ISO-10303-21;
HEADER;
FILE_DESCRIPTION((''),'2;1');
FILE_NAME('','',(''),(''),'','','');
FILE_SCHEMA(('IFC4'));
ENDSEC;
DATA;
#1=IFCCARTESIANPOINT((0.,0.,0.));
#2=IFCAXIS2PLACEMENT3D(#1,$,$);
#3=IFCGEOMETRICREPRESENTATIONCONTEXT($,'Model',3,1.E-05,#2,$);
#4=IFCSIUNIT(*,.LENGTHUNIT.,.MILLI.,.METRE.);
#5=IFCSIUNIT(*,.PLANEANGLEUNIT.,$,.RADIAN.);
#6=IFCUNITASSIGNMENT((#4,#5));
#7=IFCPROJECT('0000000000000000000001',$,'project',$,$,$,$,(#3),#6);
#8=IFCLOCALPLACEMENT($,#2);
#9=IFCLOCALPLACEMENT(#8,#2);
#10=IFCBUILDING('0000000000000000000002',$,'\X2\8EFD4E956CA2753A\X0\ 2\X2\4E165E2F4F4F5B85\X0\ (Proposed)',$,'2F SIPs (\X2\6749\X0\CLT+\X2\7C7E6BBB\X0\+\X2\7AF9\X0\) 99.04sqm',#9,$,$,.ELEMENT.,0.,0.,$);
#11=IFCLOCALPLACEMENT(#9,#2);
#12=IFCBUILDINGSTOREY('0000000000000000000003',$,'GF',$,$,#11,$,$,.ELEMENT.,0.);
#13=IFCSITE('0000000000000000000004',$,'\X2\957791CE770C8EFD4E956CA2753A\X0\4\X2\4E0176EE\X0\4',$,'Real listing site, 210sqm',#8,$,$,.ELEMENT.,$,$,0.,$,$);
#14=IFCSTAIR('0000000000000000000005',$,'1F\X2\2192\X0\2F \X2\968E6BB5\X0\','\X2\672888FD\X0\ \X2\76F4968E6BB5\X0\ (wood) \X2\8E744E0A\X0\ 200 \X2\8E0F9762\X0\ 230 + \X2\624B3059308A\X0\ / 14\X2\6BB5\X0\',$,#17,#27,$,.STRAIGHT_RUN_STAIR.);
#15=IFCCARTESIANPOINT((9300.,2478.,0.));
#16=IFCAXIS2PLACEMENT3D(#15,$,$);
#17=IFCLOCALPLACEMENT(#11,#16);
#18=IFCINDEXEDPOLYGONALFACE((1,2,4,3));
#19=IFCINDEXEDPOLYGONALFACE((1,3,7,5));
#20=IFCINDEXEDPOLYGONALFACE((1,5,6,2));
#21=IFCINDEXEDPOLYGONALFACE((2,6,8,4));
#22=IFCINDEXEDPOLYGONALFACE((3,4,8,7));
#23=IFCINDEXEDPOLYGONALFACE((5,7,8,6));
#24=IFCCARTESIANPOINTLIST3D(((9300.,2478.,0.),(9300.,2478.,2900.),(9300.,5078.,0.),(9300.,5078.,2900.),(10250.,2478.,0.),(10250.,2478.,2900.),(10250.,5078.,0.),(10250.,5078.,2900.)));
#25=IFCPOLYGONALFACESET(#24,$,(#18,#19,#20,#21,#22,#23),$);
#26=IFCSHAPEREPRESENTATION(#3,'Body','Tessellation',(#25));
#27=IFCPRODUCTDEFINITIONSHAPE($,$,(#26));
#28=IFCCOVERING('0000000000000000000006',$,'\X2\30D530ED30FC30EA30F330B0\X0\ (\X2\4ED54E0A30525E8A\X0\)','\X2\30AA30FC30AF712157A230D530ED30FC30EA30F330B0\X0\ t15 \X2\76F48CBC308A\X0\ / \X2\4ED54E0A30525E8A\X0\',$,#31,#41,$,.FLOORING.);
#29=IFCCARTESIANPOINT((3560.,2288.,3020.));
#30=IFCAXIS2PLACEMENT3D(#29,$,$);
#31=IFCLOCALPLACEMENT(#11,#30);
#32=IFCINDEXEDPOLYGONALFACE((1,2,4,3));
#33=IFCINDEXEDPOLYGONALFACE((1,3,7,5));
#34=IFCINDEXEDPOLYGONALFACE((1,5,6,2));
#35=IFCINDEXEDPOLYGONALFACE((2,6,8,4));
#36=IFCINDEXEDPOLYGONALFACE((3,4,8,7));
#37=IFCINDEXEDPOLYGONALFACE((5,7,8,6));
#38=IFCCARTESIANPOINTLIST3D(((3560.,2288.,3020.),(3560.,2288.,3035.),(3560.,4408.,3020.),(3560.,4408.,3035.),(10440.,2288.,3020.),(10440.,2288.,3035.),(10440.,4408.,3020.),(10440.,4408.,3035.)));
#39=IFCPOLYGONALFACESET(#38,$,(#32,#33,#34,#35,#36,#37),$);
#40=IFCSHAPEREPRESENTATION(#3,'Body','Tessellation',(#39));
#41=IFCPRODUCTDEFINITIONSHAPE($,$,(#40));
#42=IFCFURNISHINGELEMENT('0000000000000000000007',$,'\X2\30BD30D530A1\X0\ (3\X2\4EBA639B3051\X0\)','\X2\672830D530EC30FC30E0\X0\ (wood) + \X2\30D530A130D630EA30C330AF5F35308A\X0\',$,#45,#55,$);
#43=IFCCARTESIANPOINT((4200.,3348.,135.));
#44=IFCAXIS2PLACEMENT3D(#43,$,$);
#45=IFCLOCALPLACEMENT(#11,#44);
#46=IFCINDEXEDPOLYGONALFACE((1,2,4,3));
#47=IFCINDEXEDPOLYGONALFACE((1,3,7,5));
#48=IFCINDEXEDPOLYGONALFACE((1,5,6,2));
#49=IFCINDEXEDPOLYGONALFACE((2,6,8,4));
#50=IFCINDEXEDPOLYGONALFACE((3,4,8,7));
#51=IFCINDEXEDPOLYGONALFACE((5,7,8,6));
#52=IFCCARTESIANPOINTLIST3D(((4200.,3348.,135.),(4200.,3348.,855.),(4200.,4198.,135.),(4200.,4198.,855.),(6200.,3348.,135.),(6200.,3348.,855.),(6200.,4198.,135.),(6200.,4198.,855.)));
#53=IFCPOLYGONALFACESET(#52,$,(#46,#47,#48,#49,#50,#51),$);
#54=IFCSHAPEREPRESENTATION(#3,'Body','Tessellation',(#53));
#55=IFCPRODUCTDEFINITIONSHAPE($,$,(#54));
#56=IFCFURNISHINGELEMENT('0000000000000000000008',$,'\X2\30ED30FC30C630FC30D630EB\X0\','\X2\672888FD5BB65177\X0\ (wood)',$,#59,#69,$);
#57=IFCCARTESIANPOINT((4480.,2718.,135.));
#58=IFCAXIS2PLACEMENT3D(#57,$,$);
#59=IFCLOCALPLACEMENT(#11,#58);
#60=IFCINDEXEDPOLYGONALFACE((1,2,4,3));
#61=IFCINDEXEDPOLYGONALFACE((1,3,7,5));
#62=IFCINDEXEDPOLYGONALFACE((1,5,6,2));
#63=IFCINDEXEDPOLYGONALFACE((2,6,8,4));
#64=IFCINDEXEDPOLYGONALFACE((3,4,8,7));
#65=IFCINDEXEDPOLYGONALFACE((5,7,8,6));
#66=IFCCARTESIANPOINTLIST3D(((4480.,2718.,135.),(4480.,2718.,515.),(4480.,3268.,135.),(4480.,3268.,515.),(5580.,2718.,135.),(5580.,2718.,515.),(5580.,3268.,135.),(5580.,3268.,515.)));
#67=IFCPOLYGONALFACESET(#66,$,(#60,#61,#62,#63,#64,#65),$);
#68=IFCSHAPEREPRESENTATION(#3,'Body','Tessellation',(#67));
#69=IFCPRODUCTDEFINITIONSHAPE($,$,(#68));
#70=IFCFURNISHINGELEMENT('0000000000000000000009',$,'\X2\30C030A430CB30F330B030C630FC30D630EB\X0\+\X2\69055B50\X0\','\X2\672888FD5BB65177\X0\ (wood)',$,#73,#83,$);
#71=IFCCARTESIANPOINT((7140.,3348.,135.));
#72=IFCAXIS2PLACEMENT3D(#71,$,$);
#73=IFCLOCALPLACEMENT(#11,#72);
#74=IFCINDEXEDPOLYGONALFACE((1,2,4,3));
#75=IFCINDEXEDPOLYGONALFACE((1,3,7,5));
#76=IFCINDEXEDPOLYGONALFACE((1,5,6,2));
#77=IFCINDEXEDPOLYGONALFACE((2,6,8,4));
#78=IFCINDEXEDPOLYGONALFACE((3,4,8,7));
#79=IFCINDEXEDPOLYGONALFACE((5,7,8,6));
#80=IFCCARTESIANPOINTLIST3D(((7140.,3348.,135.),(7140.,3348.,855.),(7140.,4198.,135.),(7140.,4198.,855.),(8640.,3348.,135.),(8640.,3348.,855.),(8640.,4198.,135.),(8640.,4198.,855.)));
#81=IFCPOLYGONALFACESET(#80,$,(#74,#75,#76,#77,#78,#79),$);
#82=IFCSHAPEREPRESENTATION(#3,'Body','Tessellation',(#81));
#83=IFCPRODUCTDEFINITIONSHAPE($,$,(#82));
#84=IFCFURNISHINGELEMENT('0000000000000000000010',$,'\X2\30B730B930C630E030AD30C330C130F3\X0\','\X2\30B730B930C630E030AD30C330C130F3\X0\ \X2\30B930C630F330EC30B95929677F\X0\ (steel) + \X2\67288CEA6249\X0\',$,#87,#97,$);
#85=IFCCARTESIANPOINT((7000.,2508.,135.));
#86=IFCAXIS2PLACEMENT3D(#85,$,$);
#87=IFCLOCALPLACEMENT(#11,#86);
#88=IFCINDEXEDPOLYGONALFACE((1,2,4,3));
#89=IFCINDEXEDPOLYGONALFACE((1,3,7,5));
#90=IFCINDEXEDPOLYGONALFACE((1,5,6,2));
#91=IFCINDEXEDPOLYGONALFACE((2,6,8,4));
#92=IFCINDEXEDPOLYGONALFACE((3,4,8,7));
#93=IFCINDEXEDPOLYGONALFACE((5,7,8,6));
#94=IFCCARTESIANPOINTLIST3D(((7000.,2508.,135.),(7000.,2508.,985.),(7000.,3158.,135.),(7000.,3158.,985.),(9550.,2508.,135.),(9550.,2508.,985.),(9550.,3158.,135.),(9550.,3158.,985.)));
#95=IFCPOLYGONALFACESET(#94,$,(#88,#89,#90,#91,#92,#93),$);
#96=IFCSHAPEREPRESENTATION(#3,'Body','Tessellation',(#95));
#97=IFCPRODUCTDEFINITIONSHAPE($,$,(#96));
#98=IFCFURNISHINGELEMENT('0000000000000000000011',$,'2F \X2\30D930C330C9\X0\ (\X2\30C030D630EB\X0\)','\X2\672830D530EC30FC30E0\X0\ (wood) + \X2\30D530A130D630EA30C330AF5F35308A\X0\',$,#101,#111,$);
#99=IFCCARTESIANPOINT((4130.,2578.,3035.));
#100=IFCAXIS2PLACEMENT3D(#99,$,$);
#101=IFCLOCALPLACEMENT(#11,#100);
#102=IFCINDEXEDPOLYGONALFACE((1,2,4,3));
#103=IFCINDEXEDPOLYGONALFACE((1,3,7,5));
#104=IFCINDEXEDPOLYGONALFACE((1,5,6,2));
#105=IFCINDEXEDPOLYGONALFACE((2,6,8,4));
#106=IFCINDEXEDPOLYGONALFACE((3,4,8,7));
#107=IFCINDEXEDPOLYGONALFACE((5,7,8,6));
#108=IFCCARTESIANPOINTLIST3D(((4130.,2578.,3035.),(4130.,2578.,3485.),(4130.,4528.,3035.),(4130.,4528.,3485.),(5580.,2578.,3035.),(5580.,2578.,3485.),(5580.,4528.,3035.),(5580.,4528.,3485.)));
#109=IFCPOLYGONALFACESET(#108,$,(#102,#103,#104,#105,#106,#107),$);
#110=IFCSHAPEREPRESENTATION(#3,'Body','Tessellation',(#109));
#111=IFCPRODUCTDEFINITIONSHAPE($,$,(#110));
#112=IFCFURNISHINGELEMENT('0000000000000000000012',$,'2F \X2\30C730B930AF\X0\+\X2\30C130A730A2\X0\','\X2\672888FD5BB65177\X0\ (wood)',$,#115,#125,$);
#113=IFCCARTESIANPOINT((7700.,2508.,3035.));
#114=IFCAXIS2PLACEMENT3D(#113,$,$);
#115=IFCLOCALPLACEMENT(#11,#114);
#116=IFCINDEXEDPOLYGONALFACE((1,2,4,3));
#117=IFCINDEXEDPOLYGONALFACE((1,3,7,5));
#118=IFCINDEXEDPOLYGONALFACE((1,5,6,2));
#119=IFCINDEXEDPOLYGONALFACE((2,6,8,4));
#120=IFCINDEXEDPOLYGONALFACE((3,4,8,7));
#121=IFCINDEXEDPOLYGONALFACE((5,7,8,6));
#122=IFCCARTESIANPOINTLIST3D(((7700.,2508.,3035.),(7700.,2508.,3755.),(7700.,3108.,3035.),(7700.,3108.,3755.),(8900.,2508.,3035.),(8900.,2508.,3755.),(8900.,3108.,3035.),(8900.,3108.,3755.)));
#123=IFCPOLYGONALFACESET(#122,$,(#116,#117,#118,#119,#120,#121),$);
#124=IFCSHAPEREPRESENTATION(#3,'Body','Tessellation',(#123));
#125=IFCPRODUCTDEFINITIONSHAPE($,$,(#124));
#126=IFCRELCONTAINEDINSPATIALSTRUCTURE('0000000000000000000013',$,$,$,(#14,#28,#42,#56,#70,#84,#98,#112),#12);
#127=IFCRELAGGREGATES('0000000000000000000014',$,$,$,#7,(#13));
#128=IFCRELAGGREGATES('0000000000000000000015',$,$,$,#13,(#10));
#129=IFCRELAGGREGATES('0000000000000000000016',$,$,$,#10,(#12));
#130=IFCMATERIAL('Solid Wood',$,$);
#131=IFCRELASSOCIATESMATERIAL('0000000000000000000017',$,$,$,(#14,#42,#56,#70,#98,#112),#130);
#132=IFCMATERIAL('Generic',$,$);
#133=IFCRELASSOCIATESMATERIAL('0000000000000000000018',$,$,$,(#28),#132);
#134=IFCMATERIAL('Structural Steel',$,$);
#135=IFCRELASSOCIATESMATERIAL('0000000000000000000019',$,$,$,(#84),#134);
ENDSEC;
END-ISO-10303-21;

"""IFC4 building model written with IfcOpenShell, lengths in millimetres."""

from ifc_helpers import new_model, si_unit, frame, frame_2d, origin, place, context, project, spatial, rectangle, extrude, material, element, save


model = new_model("IFC4")

# Units and contexts
model_context = context("Model", 3, precision=1e-05, world=origin())
ifc_project = project(units=[si_unit("LENGTHUNIT", "METRE", prefix="MILLI"), si_unit("PLANEANGLEUNIT", "RADIAN")], contexts=[model_context])

# Site, building, storey
site_placement = place(None, origin())
site = spatial("IfcSite", under=ifc_project, at=site_placement, Name="長野県軽井沢町4丁目4", ObjectType="Real listing site, 210sqm", CompositionType="ELEMENT", RefElevation=0.0)
building_placement = place(site_placement, origin())
building = spatial("IfcBuilding", under=site, at=building_placement, Name="軽井沢町 2世帯住宅 (Proposed)", ObjectType="2F SIPs (杉CLT+籾殻+竹) 99.04sqm", CompositionType="ELEMENT", ElevationOfRefHeight=0.0, ElevationOfTerrain=0.0)
storey_placement = place(building_placement, origin())
storey = spatial("IfcBuildingStorey", under=building, at=storey_placement, Name="GF", CompositionType="ELEMENT", Elevation=0.0)

# Shared definitions
ifc_material_1 = material(Name="Solid Wood")

# Shared definitions
ifc_material_2 = material(Name="Generic")

# Stair
stair_placement = place(storey_placement, frame((9300.0, 2478.0, 0.0)))
element("IfcStair", 1, at=stair_placement, inside=storey, material=ifc_material_1, Name="1F→2F 階段", Description="木製 直階段 (wood) 蹴上 200 踏面 230 + 手すり / 14段", PredefinedType="STRAIGHT_RUN_STAIR", context=model_context, shape_type="SweptSolid", body=[
    extrude(rectangle(XDim=950.0, YDim=2600.0, at=frame_2d((475.0, 1300.0))), frame((9300.0, 2478.0, 0.0)), (0.0, 0.0, 1.0), 2900.0),
])

# Covering
covering_placement = place(storey_placement, frame((3560.0, 2288.0, 3020.0)))
element("IfcCovering", 2, at=covering_placement, inside=storey, material=ifc_material_2, Name="フローリング (仕上げ床)", Description="オーク無垢フローリング t15 直貼り / 仕上げ床", PredefinedType="FLOORING", context=model_context, shape_type="SweptSolid", body=[
    extrude(rectangle(XDim=6880.0, YDim=2120.0, at=frame_2d((3440.0, 1060.0))), frame((3560.0, 2288.0, 3020.0)), (0.0, 0.0, 1.0), 15.0),
])

# Furnishing elements
furnishing_1_placement = place(storey_placement, frame((4200.0, 3348.0, 135.0)))
element("IfcFurnishingElement", 3, at=furnishing_1_placement, inside=storey, material=ifc_material_1, Name="ソファ (3人掛け)", Description="木フレーム (wood) + ファブリック張り", context=model_context, shape_type="SweptSolid", body=[
    extrude(rectangle(XDim=2000.0, YDim=850.0, at=frame_2d((1000.0, 425.0))), frame((4200.0, 3348.0, 135.0)), (0.0, 0.0, 1.0), 720.0),
])
furnishing_2_placement = place(storey_placement, frame((4480.0, 2718.0, 135.0)))
element("IfcFurnishingElement", 4, at=furnishing_2_placement, inside=storey, material=ifc_material_1, Name="ローテーブル", Description="木製家具 (wood)", context=model_context, shape_type="SweptSolid", body=[
    extrude(rectangle(XDim=1100.0, YDim=550.0, at=frame_2d((550.0, 275.0))), frame((4480.0, 2718.0, 135.0)), (0.0, 0.0, 1.0), 380.0),
])
furnishing_3_placement = place(storey_placement, frame((7140.0, 3348.0, 135.0)))
element("IfcFurnishingElement", 5, at=furnishing_3_placement, inside=storey, material=ifc_material_1, Name="ダイニングテーブル+椅子", Description="木製家具 (wood)", context=model_context, shape_type="SweptSolid", body=[
    extrude(rectangle(XDim=1500.0, YDim=850.0, at=frame_2d((750.0, 425.0))), frame((7140.0, 3348.0, 135.0)), (0.0, 0.0, 1.0), 720.0),
])
ifc_material_3 = material(Name="Structural Steel")
furnishing_4_placement = place(storey_placement, frame((7000.0, 2508.0, 135.0)))
element("IfcFurnishingElement", 6, at=furnishing_4_placement, inside=storey, material=ifc_material_3, Name="システムキッチン", Description="システムキッチン ステンレス天板 (steel) + 木質扉", context=model_context, shape_type="SweptSolid", body=[
    extrude(rectangle(XDim=2550.0, YDim=650.0, at=frame_2d((1275.0, 325.0))), frame((7000.0, 2508.0, 135.0)), (0.0, 0.0, 1.0), 850.0),
])
furnishing_5_placement = place(storey_placement, frame((4130.0, 2578.0, 3035.0)))
element("IfcFurnishingElement", 7, at=furnishing_5_placement, inside=storey, material=ifc_material_1, Name="2F ベッド (ダブル)", Description="木フレーム (wood) + ファブリック張り", context=model_context, shape_type="SweptSolid", body=[
    extrude(rectangle(XDim=1450.0, YDim=1950.0, at=frame_2d((725.0, 975.0))), frame((4130.0, 2578.0, 3035.0)), (0.0, 0.0, 1.0), 450.0),
])
furnishing_6_placement = place(storey_placement, frame((7700.0, 2508.0, 3035.0)))
element("IfcFurnishingElement", 8, at=furnishing_6_placement, inside=storey, material=ifc_material_1, Name="2F デスク+チェア", Description="木製家具 (wood)", context=model_context, shape_type="SweptSolid", body=[
    extrude(rectangle(XDim=1200.0, YDim=600.0, at=frame_2d((600.0, 300.0))), frame((7700.0, 2508.0, 3035.0)), (0.0, 0.0, 1.0), 720.0),
])

save(model, "model.ifc")
